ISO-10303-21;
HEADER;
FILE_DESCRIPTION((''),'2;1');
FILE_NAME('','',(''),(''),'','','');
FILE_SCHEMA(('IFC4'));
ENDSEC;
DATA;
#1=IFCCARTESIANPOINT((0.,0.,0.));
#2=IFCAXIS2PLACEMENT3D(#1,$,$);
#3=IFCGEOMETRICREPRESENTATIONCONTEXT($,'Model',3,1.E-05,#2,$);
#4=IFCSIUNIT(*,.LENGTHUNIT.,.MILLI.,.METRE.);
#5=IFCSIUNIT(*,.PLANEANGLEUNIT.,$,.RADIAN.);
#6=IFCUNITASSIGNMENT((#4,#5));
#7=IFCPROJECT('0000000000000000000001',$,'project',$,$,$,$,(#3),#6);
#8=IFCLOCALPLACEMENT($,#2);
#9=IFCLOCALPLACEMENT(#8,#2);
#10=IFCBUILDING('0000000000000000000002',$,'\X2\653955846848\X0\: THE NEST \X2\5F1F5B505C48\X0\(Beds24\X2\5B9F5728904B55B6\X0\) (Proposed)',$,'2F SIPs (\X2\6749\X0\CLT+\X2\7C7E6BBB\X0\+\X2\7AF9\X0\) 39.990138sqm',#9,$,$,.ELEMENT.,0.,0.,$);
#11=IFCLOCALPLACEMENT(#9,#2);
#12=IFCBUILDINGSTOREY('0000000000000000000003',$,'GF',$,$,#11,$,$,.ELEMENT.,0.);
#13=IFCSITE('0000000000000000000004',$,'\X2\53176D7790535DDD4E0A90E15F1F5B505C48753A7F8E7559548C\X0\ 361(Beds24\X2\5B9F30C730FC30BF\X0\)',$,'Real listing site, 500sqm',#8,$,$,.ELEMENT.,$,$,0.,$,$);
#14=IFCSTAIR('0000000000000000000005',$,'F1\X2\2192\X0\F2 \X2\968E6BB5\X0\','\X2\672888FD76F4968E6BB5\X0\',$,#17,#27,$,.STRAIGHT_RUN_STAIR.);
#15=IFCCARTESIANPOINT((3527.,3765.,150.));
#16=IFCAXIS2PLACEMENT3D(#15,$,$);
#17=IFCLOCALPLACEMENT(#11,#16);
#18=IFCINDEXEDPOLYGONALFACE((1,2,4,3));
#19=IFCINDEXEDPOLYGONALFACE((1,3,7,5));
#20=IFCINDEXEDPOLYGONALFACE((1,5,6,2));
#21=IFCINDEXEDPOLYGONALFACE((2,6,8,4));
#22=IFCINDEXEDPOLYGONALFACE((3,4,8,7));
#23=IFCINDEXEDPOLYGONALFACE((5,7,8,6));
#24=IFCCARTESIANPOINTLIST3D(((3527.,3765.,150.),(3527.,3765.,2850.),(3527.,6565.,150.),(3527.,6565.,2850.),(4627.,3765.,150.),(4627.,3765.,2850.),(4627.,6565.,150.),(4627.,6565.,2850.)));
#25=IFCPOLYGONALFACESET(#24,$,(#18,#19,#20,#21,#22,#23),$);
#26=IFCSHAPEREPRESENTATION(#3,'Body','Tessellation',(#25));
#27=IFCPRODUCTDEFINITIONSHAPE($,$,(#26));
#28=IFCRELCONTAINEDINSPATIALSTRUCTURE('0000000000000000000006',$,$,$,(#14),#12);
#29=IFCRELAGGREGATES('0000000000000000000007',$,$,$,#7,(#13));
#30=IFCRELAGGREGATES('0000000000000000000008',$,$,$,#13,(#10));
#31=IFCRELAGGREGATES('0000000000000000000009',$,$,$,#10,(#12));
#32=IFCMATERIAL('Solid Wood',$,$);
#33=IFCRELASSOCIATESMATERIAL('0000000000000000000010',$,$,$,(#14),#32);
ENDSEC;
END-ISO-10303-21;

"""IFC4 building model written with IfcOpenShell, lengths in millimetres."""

from ifc_helpers import new_model, si_unit, frame, frame_2d, origin, place, context, project, spatial, rectangle, extrude, material, element, save


model = new_model("IFC4")

# Units and contexts
model_context = context("Model", 3, precision=1e-05, world=origin())
ifc_project = project(units=[si_unit("LENGTHUNIT", "METRE", prefix="MILLI"), si_unit("PLANEANGLEUNIT", "RADIAN")], contexts=[model_context])

# Site, building, storey
site_placement = place(None, origin())
site = spatial("IfcSite", under=ifc_project, at=site_placement, Name="北海道川上郡弟子屈町美留和 361(Beds24実データ)", ObjectType="Real listing site, 500sqm", CompositionType="ELEMENT", RefElevation=0.0)
building_placement = place(site_placement, origin())
building = spatial("IfcBuilding", under=site, at=building_placement, Name="改善案: THE NEST 弟子屈(Beds24実在運営) (Proposed)", ObjectType="2F SIPs (杉CLT+籾殻+竹) 39.990138sqm", CompositionType="ELEMENT", ElevationOfRefHeight=0.0, ElevationOfTerrain=0.0)
storey_placement = place(building_placement, origin())
storey = spatial("IfcBuildingStorey", under=building, at=storey_placement, Name="GF", CompositionType="ELEMENT", Elevation=0.0)

# Stair
ifc_material_1 = material(Name="Solid Wood")
stair_placement = place(storey_placement, frame((3527.0, 3765.0, 150.0)))
element("IfcStair", 1, at=stair_placement, inside=storey, material=ifc_material_1, Name="F1→F2 階段", Description="木製直階段", PredefinedType="STRAIGHT_RUN_STAIR", context=model_context, shape_type="SweptSolid", body=[
    extrude(rectangle(XDim=1100.0, YDim=2800.0, at=frame_2d((550.0, 1400.0))), frame((3527.0, 3765.0, 150.0)), (0.0, 0.0, 1.0), 2700.0),
])

save(model, "model.ifc")
